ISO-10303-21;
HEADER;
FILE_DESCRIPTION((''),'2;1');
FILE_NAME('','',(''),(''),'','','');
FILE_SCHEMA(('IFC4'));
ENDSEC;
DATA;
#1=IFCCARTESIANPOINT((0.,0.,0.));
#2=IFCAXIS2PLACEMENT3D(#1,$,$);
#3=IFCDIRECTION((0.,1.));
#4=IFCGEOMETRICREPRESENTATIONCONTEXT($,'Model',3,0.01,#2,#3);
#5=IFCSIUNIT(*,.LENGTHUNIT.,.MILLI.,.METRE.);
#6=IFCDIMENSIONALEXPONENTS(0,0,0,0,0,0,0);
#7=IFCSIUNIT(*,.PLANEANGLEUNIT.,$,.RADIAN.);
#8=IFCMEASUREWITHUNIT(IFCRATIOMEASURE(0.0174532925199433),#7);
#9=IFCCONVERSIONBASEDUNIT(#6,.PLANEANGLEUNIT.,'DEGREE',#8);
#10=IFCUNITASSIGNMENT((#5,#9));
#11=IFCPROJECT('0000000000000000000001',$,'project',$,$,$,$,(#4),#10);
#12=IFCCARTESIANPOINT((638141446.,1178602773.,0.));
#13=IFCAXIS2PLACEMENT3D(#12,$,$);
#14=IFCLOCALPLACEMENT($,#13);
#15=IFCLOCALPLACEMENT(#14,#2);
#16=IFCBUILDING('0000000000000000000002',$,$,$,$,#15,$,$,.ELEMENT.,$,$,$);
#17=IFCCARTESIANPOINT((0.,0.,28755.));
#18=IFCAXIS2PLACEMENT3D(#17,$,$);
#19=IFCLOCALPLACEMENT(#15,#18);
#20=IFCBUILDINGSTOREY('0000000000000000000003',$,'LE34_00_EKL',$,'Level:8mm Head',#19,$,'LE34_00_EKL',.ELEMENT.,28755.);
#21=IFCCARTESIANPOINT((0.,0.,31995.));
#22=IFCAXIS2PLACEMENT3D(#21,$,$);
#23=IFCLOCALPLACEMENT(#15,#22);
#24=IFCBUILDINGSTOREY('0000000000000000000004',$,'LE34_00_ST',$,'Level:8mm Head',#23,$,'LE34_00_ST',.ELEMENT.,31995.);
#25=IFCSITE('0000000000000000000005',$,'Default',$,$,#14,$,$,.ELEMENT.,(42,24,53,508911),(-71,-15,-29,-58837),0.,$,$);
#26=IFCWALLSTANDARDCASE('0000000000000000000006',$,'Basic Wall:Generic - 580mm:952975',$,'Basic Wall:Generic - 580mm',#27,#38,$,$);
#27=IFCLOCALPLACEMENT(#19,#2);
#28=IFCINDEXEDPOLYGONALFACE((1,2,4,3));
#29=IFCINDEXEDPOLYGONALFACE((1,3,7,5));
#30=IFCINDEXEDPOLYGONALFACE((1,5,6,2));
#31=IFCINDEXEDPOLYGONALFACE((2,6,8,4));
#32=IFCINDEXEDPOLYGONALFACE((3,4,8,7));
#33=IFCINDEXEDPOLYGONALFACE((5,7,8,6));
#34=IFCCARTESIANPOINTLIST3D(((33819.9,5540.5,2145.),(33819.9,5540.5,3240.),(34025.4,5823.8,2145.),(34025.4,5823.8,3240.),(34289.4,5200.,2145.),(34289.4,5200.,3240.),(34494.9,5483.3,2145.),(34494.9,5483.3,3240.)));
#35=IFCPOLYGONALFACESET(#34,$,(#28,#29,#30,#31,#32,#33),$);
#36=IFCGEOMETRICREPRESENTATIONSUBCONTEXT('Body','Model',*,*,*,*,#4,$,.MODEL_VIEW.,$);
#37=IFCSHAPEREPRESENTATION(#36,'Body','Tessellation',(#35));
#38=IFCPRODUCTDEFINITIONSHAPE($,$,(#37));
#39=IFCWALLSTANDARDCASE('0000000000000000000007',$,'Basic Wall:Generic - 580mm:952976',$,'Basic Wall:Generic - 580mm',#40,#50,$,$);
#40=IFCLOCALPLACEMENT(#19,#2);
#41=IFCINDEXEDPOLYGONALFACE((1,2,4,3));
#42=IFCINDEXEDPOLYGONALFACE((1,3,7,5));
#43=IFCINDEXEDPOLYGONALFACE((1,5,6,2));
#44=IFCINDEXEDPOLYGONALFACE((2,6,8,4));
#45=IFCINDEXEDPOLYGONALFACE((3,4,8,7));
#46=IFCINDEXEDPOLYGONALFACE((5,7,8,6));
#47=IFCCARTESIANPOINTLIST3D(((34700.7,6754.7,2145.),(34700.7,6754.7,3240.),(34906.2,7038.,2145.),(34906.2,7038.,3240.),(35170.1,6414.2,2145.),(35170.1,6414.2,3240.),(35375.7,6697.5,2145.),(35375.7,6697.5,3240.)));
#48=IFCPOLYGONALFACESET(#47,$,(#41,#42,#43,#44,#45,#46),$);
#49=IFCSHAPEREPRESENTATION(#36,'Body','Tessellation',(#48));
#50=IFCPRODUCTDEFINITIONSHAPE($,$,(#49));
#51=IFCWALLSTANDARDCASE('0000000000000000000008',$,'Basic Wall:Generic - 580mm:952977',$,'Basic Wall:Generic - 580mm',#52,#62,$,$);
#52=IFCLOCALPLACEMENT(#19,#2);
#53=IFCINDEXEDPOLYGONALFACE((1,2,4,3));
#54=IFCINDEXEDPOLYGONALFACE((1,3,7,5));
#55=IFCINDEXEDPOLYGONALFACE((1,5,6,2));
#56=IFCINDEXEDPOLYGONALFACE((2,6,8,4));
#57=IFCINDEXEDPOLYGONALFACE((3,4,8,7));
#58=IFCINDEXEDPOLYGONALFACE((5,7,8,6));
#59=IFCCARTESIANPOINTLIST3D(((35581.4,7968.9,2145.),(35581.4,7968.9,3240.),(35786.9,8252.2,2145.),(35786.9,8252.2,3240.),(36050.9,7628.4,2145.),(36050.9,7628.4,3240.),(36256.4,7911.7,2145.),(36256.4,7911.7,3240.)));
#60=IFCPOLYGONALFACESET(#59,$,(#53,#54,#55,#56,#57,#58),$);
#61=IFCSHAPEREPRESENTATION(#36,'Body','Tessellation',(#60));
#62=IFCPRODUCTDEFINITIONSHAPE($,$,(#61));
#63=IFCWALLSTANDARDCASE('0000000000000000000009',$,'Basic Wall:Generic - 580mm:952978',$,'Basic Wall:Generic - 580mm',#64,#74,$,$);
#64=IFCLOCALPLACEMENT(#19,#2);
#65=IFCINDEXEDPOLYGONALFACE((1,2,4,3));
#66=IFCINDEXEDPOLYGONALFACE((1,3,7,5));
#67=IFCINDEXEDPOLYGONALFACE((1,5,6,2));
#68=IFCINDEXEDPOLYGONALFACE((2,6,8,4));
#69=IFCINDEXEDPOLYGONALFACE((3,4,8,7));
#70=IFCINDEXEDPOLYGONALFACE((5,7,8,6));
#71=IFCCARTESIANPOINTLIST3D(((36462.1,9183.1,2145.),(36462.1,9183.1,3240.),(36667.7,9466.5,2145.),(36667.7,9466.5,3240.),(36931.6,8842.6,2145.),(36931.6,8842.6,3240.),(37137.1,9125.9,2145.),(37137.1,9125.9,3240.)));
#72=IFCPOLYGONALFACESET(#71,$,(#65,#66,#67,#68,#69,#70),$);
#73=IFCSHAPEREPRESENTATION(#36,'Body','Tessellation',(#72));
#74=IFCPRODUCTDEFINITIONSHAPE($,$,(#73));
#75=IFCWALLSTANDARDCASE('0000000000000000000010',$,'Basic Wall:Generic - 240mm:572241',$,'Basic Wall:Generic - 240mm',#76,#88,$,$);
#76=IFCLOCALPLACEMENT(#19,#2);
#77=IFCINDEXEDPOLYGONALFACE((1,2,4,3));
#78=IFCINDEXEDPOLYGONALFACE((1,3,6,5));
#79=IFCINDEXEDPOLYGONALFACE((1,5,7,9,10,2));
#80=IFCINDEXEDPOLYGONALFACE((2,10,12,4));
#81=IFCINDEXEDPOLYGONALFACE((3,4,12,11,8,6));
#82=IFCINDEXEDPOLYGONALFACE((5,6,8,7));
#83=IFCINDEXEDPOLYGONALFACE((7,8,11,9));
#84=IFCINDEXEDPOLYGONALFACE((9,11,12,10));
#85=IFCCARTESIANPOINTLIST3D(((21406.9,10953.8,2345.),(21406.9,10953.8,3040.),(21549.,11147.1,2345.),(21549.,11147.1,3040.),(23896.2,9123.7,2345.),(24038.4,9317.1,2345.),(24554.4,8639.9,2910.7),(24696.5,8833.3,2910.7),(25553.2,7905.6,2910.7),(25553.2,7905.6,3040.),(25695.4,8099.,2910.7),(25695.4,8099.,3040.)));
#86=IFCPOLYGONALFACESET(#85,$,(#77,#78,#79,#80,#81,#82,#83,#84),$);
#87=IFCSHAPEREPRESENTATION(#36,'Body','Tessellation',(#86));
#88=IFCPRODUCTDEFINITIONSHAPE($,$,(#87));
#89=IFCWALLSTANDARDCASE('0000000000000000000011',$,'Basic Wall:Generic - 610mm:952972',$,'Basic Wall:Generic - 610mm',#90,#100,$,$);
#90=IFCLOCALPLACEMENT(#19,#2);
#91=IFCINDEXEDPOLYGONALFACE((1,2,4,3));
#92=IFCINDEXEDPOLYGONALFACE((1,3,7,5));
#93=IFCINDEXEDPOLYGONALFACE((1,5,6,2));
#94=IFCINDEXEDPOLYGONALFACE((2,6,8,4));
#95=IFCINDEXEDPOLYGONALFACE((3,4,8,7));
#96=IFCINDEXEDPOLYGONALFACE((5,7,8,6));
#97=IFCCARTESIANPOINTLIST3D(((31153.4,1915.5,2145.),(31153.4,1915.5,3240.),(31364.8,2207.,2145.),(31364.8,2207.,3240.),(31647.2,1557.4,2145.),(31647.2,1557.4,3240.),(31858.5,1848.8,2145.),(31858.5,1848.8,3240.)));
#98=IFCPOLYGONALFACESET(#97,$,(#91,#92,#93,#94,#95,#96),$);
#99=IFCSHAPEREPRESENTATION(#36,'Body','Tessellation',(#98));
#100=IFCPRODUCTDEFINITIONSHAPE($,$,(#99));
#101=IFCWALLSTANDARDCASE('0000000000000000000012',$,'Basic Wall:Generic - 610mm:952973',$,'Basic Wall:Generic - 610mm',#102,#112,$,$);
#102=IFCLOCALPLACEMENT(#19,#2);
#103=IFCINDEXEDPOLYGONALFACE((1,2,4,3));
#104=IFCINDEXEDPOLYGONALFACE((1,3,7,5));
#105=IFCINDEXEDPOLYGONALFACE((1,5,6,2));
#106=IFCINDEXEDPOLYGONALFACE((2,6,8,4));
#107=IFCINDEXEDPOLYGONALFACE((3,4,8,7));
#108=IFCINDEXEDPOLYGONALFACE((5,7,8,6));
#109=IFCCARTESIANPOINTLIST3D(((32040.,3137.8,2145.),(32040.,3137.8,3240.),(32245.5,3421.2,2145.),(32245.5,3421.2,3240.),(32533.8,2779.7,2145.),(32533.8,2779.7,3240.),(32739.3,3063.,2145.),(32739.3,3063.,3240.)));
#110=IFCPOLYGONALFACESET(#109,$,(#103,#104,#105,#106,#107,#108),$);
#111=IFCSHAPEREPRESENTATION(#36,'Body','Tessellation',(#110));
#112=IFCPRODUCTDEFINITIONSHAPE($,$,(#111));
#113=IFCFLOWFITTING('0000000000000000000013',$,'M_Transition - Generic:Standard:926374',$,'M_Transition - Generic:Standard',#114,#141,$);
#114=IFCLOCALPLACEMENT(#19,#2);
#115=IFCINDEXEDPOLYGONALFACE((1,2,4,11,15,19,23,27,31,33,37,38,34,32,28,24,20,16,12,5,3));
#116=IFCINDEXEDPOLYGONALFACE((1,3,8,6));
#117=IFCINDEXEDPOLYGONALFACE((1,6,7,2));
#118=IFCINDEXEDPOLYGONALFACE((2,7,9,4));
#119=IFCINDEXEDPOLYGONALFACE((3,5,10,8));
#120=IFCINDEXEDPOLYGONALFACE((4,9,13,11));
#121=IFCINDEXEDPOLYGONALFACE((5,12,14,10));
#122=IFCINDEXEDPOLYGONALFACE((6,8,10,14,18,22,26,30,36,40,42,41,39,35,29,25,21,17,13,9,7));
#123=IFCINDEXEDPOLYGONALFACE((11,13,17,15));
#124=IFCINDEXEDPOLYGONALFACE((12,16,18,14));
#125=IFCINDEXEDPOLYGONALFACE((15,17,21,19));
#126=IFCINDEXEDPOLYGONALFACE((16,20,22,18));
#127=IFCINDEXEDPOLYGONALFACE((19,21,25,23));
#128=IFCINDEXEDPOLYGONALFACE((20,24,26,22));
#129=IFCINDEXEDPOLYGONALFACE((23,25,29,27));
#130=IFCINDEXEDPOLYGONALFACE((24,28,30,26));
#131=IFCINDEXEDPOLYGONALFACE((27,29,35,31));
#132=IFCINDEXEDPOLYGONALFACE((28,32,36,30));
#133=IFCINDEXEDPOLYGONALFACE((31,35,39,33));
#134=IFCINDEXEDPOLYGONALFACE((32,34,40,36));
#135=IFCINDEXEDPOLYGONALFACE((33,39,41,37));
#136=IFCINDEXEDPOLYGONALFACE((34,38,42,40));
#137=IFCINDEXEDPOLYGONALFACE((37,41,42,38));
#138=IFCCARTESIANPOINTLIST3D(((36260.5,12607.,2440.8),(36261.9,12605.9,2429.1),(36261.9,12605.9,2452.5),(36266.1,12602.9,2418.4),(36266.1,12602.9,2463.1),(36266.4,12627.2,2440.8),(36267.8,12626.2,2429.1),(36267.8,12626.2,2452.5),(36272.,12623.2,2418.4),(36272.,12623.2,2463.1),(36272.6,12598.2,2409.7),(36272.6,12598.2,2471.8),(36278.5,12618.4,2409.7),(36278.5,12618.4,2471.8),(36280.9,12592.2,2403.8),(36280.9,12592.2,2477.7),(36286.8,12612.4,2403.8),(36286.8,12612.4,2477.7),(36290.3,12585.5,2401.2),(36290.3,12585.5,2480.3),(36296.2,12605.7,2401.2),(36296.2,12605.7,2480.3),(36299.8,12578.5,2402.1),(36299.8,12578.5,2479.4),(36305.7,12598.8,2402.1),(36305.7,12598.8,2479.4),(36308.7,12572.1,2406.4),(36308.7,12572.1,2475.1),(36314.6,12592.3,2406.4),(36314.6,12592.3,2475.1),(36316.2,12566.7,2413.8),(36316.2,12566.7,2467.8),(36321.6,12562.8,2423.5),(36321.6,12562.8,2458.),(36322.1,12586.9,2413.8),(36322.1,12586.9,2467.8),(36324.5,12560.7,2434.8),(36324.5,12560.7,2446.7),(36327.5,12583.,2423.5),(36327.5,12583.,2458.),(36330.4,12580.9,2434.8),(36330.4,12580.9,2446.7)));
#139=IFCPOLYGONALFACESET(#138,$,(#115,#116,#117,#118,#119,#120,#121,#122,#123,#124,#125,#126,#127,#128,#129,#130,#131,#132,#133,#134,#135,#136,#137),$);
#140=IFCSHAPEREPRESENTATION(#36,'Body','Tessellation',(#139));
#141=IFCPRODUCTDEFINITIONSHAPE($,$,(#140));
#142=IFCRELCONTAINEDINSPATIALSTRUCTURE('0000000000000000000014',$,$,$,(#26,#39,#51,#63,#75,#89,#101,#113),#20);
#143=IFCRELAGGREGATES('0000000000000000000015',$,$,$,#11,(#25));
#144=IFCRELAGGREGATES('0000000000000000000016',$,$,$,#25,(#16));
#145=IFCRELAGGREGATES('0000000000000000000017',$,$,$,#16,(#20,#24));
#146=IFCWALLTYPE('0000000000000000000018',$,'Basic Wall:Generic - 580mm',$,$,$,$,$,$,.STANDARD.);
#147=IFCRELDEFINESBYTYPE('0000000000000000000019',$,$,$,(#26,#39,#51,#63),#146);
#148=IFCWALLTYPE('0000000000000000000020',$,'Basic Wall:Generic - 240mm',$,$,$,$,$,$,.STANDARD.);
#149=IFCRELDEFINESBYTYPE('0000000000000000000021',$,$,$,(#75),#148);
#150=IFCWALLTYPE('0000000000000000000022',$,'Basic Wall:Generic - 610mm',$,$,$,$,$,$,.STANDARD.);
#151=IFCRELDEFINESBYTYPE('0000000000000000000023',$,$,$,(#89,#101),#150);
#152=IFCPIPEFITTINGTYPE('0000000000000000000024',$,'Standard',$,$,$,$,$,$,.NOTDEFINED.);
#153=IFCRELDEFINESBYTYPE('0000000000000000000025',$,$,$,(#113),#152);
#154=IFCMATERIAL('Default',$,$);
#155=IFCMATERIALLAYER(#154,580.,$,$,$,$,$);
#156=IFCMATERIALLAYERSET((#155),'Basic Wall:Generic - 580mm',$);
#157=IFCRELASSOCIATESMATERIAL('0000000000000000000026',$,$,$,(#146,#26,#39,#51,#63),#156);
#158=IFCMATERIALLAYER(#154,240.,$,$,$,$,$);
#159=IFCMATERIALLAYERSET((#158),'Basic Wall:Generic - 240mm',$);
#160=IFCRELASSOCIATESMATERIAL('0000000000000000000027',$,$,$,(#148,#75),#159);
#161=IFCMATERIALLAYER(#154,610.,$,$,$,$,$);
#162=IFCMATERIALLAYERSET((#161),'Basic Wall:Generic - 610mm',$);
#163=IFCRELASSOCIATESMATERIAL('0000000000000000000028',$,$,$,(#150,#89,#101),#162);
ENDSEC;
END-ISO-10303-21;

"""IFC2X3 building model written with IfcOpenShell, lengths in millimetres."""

from ifc_helpers import new_model, entity, si_unit, converted_unit, direction, frame, frame_2d, origin, place, context, subcontext, project, spatial, polyline, rectangle, circle, outline, extrude, source, transform, mapped, material, layer, layer_set, layer_usage, type_object, type_shapes, element, save


model = new_model("IFC2X3")

# Units and contexts
model_context = context("Model", 3, precision=0.01, world=origin(), true_north=direction((0.0, 1.0)))
body_context = subcontext(model_context, "Body", "Model", "MODEL_VIEW")
ifc_project = project(units=[si_unit("LENGTHUNIT", "METRE", prefix="MILLI"), converted_unit("PLANEANGLEUNIT", "DEGREE", entity("IfcRatioMeasure", 0.0174532925199433), si_unit("PLANEANGLEUNIT", "RADIAN"), dimensions=[0, 0, 0, 0, 0, 0, 0])], contexts=[model_context])

# Site, building, storey
site_placement = place(None, frame((638141446.0, 1178602773.0, 0.0)))
site = spatial("IfcSite", under=ifc_project, at=site_placement, Name="Default", CompositionType="ELEMENT", RefLatitude=(42, 24, 53, 508911), RefLongitude=(-71, -15, -29, -58837), RefElevation=0.0)
building_placement = place(site_placement, origin())
building = spatial("IfcBuilding", under=site, at=building_placement, CompositionType="ELEMENT")
storey_1_placement = place(building_placement, frame((0.0, 0.0, 28755.0)))
storey_1 = spatial("IfcBuildingStorey", under=building, at=storey_1_placement, Name="LE34_00_EKL", ObjectType="Level:8mm Head", LongName="LE34_00_EKL", CompositionType="ELEMENT", Elevation=28755.0)

# Shared definitions
ifc_material_1 = material(Name="Default")

# Shared definitions
storey_2_placement = place(building_placement, frame((0.0, 0.0, 31995.0)))
storey_2 = spatial("IfcBuildingStorey", under=building, at=storey_2_placement, Name="LE34_00_ST", ObjectType="Level:8mm Head", LongName="LE34_00_ST", CompositionType="ELEMENT", Elevation=31995.0)

# Walls
ifc_layer_1 = layer(ifc_material_1, 580.0)
ifc_layer_set_1 = layer_set([ifc_layer_1], Name="Basic Wall:Generic - 580mm")
wall_type_1 = type_object("IfcWallType", Name="Basic Wall:Generic - 580mm", PredefinedType="STANDARD", material=ifc_layer_set_1)
ifc_layer_usage_1 = layer_usage(ifc_layer_set_1, "AXIS2", "NEGATIVE", 290.0)
wall_1_placement = place(storey_1_placement, frame((34260.2, 5653.6, 2145.0), z_axis=(0.0, 0.0, 1.0), x_axis=(-0.587164, -0.809468, 0.0)))
element("IfcWallStandardCase", 1, at=wall_1_placement, inside=storey_1, type_object=wall_type_1, material=ifc_layer_usage_1, Name="Basic Wall:Generic - 580mm:952975", ObjectType="Basic Wall:Generic - 580mm", context=body_context, shape_type="SweptSolid", body=[
    extrude(rectangle(XDim=350.0, YDim=580.0, at=frame_2d((175.0, 0.0), x_axis=(-1.0, 0.0))), origin(), (0.0, 0.0, 1.0), 1095.0),
])
ifc_layer_usage_2 = layer_usage(ifc_layer_set_1, "AXIS2", "NEGATIVE", 290.0)
wall_2_placement = place(storey_1_placement, frame((35140.9, 6867.8, 2145.0), z_axis=(0.0, 0.0, 1.0), x_axis=(-0.587164, -0.809468, 0.0)))
element("IfcWallStandardCase", 2, at=wall_2_placement, inside=storey_1, type_object=wall_type_1, material=ifc_layer_usage_2, Name="Basic Wall:Generic - 580mm:952976", ObjectType="Basic Wall:Generic - 580mm", context=body_context, shape_type="SweptSolid", body=[
    extrude(rectangle(XDim=350.0, YDim=580.0, at=frame_2d((175.0, 0.0), x_axis=(-1.0, 0.0))), origin(), (0.0, 0.0, 1.0), 1095.0),
])
ifc_layer_usage_3 = layer_usage(ifc_layer_set_1, "AXIS2", "NEGATIVE", 290.0)
wall_3_placement = place(storey_1_placement, frame((36021.7, 8082.0, 2145.0), z_axis=(0.0, 0.0, 1.0), x_axis=(-0.587164, -0.809468, 0.0)))
element("IfcWallStandardCase", 3, at=wall_3_placement, inside=storey_1, type_object=wall_type_1, material=ifc_layer_usage_3, Name="Basic Wall:Generic - 580mm:952977", ObjectType="Basic Wall:Generic - 580mm", context=body_context, shape_type="SweptSolid", body=[
    extrude(rectangle(XDim=350.0, YDim=580.0, at=frame_2d((175.0, 0.0), x_axis=(-1.0, 0.0))), origin(), (0.0, 0.0, 1.0), 1095.0),
])
ifc_layer_usage_4 = layer_usage(ifc_layer_set_1, "AXIS2", "NEGATIVE", 290.0)
wall_4_placement = place(storey_1_placement, frame((36902.4, 9296.2, 2145.0), z_axis=(0.0, 0.0, 1.0), x_axis=(-0.587164, -0.809468, 0.0)))
element("IfcWallStandardCase", 4, at=wall_4_placement, inside=storey_1, type_object=wall_type_1, material=ifc_layer_usage_4, Name="Basic Wall:Generic - 580mm:952978", ObjectType="Basic Wall:Generic - 580mm", context=body_context, shape_type="SweptSolid", body=[
    extrude(rectangle(XDim=350.0, YDim=580.0, at=frame_2d((175.0, 0.0), x_axis=(-1.0, 0.0))), origin(), (0.0, 0.0, 1.0), 1095.0),
])

# Wall, opening
ifc_layer_2 = layer(ifc_material_1, 240.0)
ifc_layer_set_2 = layer_set([ifc_layer_2], Name="Basic Wall:Generic - 240mm")
ifc_layer_usage_5 = layer_usage(ifc_layer_set_2, "AXIS2", "NEGATIVE", 120.0)
wall_type_2 = type_object("IfcWallType", Name="Basic Wall:Generic - 240mm", PredefinedType="STANDARD", material=ifc_layer_set_2)
wall_5_placement = place(storey_1_placement, frame((25624.3, 8002.3, 2345.0), z_axis=(0.0, 0.0, 1.0), x_axis=(-0.805709, 0.592312, 0.0)))
wall_5 = element("IfcWallStandardCase", 5, at=wall_5_placement, inside=storey_1, type_object=wall_type_2, material=ifc_layer_usage_5, Name="Basic Wall:Generic - 240mm:572241", ObjectType="Basic Wall:Generic - 240mm", context=body_context, shape_type="SweptSolid", body=[
    extrude(rectangle(XDim=5146.2, YDim=240.0, at=frame_2d((2573.1, 0.0), x_axis=(-1.0, 0.0))), origin(), (0.0, 0.0, 1.0), 695.0),
])
opening_1_placement = place(wall_5_placement, origin())
element("IfcOpeningElement", 6, at=opening_1_placement, cuts=wall_5, ObjectType="Opening", context=body_context, shape_type="SweptSolid", body=[
    extrude(outline(polyline([(-282.9, -824.1), (282.9, -824.1), (282.9, 1232.5), (-282.9, 415.6), (-282.9, -824.1)])), frame((824.1, 120.0, 282.9), z_axis=(0.0, -1.0, 0.0), x_axis=(0.0, 0.0, -1.0)), (0.0, 0.0, 1.0), 240.0),
])

# Walls
ifc_layer_3 = layer(ifc_material_1, 610.0)
ifc_layer_set_3 = layer_set([ifc_layer_3], Name="Basic Wall:Generic - 610mm")
ifc_layer_usage_6 = layer_usage(ifc_layer_set_3, "AXIS2", "NEGATIVE", 305.0)
wall_type_3 = type_object("IfcWallType", Name="Basic Wall:Generic - 610mm", PredefinedType="STANDARD", material=ifc_layer_set_3)
wall_6_placement = place(storey_1_placement, frame((31611.6, 2027.9, 2145.0), z_axis=(0.0, 0.0, 1.0), x_axis=(-0.587164, -0.809468, 0.0)))
element("IfcWallStandardCase", 7, at=wall_6_placement, inside=storey_1, type_object=wall_type_3, material=ifc_layer_usage_6, Name="Basic Wall:Generic - 610mm:952972", ObjectType="Basic Wall:Generic - 610mm", context=body_context, shape_type="SweptSolid", body=[
    extrude(rectangle(XDim=360.0, YDim=610.0, at=frame_2d((180.0, 0.0), x_axis=(-1.0, 0.0))), origin(), (0.0, 0.0, 1.0), 1095.0),
])
ifc_layer_usage_7 = layer_usage(ifc_layer_set_3, "AXIS2", "NEGATIVE", 305.0)
wall_7_placement = place(storey_1_placement, frame((32492.4, 3242.1, 2145.0), z_axis=(0.0, 0.0, 1.0), x_axis=(-0.587164, -0.809468, 0.0)))
element("IfcWallStandardCase", 8, at=wall_7_placement, inside=storey_1, type_object=wall_type_3, material=ifc_layer_usage_7, Name="Basic Wall:Generic - 610mm:952973", ObjectType="Basic Wall:Generic - 610mm", context=body_context, shape_type="SweptSolid", body=[
    extrude(rectangle(XDim=350.0, YDim=610.0, at=frame_2d((175.0, 0.0), x_axis=(-1.0, 0.0))), origin(), (0.0, 0.0, 1.0), 1095.0),
])

# Flow fitting
pipe_fitting_type = type_object("IfcPipeFittingType", Name="Standard", PredefinedType="NOTDEFINED")
shared_shape_1 = source(origin(), body_context, "Body", "SweptSolid", [
    extrude(circle(Radius=39.7, at=frame_2d((0.0, 0.0), x_axis=(1.0, 0.0))), frame((0.0, 0.0, 0.0), z_axis=(1.0, 0.0, 0.0), x_axis=(0.0, 1.0, 0.0)), (0.335697, 0.0, 0.94197), 21.1),
])
type_shapes(pipe_fitting_type, [shared_shape_1])
flow_fitting_placement = place(storey_1_placement, frame((36292.7, 12583.7, 2440.8), z_axis=(0.0, 0.0, 1.0), x_axis=(0.586069, 0.810261, 0.0)))
element("IfcFlowFitting", 9, at=flow_fitting_placement, inside=storey_1, type_object=pipe_fitting_type, Name="M_Transition - Generic:Standard:926374", ObjectType="M_Transition - Generic:Standard", context=body_context, shape_type="MappedRepresentation", body=[
    mapped(shared_shape_1, transform((0.0, 0.0, 0.0), scale=1.0)),
])

save(model, "model.ifc")
